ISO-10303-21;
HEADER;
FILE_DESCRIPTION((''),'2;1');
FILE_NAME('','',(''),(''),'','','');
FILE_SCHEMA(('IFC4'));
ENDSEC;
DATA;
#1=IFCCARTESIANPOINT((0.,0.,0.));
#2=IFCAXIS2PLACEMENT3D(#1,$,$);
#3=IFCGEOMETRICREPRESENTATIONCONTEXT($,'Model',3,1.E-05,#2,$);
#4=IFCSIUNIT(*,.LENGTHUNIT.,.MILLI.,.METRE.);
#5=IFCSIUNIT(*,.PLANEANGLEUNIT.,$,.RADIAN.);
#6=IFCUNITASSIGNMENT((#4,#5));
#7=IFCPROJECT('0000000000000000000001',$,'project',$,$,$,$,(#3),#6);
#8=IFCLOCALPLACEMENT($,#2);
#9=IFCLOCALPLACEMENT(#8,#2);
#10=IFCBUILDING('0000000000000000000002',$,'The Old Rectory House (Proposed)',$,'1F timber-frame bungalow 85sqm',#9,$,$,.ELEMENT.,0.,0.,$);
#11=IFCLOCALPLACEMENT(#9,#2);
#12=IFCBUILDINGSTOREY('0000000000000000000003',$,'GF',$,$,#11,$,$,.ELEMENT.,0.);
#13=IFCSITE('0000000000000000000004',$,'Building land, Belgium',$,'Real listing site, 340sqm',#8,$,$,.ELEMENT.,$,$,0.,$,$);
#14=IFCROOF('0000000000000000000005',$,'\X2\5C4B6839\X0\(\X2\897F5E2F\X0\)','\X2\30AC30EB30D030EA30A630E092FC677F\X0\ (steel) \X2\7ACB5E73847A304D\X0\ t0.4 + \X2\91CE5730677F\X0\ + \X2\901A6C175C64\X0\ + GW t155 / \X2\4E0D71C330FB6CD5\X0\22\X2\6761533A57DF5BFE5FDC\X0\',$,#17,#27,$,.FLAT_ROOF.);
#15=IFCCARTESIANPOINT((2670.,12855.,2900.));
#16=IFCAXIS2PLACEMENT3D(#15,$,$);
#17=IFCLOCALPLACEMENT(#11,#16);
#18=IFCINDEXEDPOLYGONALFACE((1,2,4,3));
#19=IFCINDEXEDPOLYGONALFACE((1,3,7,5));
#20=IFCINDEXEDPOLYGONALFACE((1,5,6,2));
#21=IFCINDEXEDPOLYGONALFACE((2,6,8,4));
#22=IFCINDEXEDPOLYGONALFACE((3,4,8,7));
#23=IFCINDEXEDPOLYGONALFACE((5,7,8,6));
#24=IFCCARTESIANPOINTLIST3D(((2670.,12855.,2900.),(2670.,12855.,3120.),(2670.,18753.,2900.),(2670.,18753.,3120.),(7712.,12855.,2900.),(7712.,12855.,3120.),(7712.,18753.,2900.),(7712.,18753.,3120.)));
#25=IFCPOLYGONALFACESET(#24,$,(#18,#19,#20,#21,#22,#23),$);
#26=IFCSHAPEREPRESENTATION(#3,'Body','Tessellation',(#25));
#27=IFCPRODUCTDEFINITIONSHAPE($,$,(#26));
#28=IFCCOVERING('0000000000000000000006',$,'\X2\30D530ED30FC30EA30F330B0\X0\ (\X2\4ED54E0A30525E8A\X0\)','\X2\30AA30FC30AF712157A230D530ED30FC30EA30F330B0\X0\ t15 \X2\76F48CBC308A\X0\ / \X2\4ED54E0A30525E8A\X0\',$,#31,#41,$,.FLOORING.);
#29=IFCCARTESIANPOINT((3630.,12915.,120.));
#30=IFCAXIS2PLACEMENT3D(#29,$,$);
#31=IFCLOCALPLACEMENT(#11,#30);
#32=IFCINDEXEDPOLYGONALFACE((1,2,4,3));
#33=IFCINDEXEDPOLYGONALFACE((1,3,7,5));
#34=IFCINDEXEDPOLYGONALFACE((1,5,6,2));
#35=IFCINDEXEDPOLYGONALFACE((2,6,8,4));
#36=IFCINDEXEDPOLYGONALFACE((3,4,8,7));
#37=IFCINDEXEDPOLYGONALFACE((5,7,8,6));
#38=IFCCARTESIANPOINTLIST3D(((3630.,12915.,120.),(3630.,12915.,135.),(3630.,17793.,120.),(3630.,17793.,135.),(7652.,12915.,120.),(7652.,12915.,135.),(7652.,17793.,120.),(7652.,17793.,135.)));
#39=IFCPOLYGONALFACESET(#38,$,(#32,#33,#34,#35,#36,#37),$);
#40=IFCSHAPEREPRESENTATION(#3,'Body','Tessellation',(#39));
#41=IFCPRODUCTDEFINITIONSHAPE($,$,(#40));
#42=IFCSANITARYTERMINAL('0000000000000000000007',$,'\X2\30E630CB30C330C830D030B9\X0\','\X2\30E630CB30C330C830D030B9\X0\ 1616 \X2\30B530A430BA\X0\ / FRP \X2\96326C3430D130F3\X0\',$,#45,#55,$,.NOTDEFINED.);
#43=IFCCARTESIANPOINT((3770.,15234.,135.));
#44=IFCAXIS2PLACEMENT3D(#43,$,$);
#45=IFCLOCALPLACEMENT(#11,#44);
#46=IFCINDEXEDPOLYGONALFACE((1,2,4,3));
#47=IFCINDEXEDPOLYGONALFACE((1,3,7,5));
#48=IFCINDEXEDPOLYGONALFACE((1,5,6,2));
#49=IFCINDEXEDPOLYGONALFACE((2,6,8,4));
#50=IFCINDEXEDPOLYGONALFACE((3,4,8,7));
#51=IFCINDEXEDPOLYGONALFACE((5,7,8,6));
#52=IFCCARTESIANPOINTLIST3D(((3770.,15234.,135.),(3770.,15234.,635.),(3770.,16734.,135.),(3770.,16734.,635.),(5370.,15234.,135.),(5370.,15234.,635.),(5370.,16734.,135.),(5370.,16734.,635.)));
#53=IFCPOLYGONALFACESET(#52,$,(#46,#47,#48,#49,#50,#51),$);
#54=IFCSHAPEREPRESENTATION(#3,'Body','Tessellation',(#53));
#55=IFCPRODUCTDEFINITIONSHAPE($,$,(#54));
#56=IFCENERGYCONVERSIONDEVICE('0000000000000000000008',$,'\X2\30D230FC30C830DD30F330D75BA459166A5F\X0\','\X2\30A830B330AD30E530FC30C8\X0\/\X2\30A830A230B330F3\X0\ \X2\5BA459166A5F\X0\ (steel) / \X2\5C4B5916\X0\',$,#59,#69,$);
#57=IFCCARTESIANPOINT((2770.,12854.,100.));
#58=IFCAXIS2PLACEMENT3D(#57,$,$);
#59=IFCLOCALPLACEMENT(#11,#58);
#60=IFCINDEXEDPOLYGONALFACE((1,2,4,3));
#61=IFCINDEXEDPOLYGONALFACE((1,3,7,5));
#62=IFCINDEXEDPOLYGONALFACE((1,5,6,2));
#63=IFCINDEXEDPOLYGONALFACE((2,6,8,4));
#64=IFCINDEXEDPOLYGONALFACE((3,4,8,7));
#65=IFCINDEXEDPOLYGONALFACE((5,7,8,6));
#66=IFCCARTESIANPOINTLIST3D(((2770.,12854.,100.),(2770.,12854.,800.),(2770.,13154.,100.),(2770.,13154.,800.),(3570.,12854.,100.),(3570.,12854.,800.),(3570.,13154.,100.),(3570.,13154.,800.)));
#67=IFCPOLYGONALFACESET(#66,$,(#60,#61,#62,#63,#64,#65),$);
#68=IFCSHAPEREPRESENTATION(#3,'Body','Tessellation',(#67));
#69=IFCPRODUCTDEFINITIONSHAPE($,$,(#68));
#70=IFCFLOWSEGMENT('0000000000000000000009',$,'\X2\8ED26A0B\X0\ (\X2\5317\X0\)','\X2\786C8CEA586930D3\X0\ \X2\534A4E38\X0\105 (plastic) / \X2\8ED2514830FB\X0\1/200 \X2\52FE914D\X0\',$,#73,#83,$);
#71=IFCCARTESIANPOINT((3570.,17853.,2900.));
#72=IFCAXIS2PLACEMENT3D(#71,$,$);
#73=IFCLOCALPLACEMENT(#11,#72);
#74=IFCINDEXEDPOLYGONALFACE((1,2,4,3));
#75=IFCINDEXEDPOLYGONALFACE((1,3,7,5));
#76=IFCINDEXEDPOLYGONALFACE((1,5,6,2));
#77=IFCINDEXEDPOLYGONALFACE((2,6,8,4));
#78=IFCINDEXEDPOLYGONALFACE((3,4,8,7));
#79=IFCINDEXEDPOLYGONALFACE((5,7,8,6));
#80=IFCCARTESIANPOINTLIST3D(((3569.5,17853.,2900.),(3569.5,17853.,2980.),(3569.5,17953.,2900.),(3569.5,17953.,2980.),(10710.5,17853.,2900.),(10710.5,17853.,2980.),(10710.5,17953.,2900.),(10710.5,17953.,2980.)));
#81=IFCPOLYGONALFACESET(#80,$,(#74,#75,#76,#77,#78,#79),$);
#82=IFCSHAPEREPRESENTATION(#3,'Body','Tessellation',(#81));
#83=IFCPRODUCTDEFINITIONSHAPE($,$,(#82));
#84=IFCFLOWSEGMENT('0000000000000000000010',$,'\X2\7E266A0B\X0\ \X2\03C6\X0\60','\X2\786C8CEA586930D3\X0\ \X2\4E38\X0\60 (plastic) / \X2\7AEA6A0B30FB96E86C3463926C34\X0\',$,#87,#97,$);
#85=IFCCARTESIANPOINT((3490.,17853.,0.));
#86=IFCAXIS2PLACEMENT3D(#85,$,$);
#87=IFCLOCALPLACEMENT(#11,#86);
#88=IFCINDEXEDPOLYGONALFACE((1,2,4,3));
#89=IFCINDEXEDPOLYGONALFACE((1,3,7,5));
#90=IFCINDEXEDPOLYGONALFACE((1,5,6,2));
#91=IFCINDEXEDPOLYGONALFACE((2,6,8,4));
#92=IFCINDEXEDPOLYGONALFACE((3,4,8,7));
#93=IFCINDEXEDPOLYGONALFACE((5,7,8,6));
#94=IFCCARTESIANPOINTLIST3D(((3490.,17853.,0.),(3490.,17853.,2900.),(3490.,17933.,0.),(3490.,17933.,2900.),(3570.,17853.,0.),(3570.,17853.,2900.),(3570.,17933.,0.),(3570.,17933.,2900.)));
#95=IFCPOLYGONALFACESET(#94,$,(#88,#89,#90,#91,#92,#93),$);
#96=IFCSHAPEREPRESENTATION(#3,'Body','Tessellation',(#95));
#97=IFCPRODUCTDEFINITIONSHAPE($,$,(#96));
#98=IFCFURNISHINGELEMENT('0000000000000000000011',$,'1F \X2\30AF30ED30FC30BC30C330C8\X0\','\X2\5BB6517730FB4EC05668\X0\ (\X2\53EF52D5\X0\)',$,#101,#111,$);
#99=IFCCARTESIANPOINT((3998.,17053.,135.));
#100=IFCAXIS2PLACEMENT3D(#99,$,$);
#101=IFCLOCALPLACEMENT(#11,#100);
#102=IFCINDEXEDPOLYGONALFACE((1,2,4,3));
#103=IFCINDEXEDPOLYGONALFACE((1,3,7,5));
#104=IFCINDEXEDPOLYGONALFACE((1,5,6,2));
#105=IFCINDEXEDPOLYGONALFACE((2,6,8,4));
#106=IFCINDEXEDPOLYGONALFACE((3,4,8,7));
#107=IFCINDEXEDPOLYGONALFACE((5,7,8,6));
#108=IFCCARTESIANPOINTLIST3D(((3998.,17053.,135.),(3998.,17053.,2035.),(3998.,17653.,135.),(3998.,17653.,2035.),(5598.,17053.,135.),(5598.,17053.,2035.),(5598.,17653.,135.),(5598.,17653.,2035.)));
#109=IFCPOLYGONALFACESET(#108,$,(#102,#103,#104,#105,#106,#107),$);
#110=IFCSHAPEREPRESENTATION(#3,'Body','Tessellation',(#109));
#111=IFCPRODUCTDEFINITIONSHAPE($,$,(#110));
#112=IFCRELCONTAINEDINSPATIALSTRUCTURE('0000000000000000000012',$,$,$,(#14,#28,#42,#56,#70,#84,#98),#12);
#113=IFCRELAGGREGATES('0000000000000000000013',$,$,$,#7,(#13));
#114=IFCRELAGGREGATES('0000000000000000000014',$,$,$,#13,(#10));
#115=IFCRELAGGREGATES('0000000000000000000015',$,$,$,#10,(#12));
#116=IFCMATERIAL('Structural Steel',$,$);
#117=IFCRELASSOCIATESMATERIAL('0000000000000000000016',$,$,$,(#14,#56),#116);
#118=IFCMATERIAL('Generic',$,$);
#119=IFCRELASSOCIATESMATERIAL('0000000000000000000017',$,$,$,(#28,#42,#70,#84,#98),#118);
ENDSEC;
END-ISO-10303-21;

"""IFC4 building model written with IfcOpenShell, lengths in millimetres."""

from ifc_helpers import new_model, si_unit, frame, frame_2d, origin, place, context, project, spatial, rectangle, extrude, material, element, save


model = new_model("IFC4")

# Units and contexts
model_context = context("Model", 3, precision=1e-05, world=origin())
ifc_project = project(units=[si_unit("LENGTHUNIT", "METRE", prefix="MILLI"), si_unit("PLANEANGLEUNIT", "RADIAN")], contexts=[model_context])

# Site, building, storey
site_placement = place(None, origin())
site = spatial("IfcSite", under=ifc_project, at=site_placement, Name="Building land, Belgium", ObjectType="Real listing site, 340sqm", CompositionType="ELEMENT", RefElevation=0.0)
building_placement = place(site_placement, origin())
building = spatial("IfcBuilding", under=site, at=building_placement, Name="The Old Rectory House (Proposed)", ObjectType="1F timber-frame bungalow 85sqm", CompositionType="ELEMENT", ElevationOfRefHeight=0.0, ElevationOfTerrain=0.0)
storey_placement = place(building_placement, origin())
storey = spatial("IfcBuildingStorey", under=building, at=storey_placement, Name="GF", CompositionType="ELEMENT", Elevation=0.0)

# Roof
ifc_material_1 = material(Name="Structural Steel")
roof_placement = place(storey_placement, frame((2670.0, 12855.0, 2900.0)))
element("IfcRoof", 1, at=roof_placement, inside=storey, material=ifc_material_1, Name="屋根(西帯)", Description="ガルバリウム鋼板 (steel) 立平葺き t0.4 + 野地板 + 通気層 + GW t155 / 不燃・法22条区域対応", PredefinedType="FLAT_ROOF", context=model_context, shape_type="SweptSolid", body=[
    extrude(rectangle(XDim=5042.0, YDim=5898.0, at=frame_2d((2521.0, 2949.0))), frame((2670.0, 12855.0, 2900.0)), (0.0, 0.0, 1.0), 220.0),
])

# Covering
ifc_material_2 = material(Name="Generic")
covering_placement = place(storey_placement, frame((3630.0, 12915.0, 120.0)))
element("IfcCovering", 2, at=covering_placement, inside=storey, material=ifc_material_2, Name="フローリング (仕上げ床)", Description="オーク無垢フローリング t15 直貼り / 仕上げ床", PredefinedType="FLOORING", context=model_context, shape_type="SweptSolid", body=[
    extrude(rectangle(XDim=4022.0, YDim=4878.0, at=frame_2d((2011.0, 2439.0))), frame((3630.0, 12915.0, 120.0)), (0.0, 0.0, 1.0), 15.0),
])

# Sanitary terminal
sanitary_terminal_placement = place(storey_placement, frame((3770.0, 15234.0, 135.0)))
element("IfcSanitaryTerminal", 3, at=sanitary_terminal_placement, inside=storey, material=ifc_material_2, Name="ユニットバス", Description="ユニットバス 1616 サイズ / FRP 防水パン", PredefinedType="NOTDEFINED", context=model_context, shape_type="SweptSolid", body=[
    extrude(rectangle(XDim=1600.0, YDim=1500.0, at=frame_2d((800.0, 750.0))), frame((3770.0, 15234.0, 135.0)), (0.0, 0.0, 1.0), 500.0),
])

# Energy conversion device
energy_conversion_device_placement = place(storey_placement, frame((2770.0, 12854.0, 100.0)))
element("IfcEnergyConversionDevice", 4, at=energy_conversion_device_placement, inside=storey, material=ifc_material_1, Name="ヒートポンプ室外機", Description="エコキュート/エアコン 室外機 (steel) / 屋外", context=model_context, shape_type="SweptSolid", body=[
    extrude(rectangle(XDim=800.0, YDim=300.0, at=frame_2d((400.0, 150.0))), frame((2770.0, 12854.0, 100.0)), (0.0, 0.0, 1.0), 700.0),
])

# Flow segments
flow_segment_1_placement = place(storey_placement, frame((3570.0, 17853.0, 2900.0)))
element("IfcFlowSegment", 5, at=flow_segment_1_placement, inside=storey, material=ifc_material_2, Name="軒樋 (北)", Description="硬質塩ビ 半丸105 (plastic) / 軒先・1/200 勾配", context=model_context, shape_type="SweptSolid", body=[
    extrude(rectangle(XDim=7141.0, YDim=100.0, at=frame_2d((3570.0, 50.0))), frame((3570.0, 17853.0, 2900.0)), (0.0, 0.0, 1.0), 80.0),
])
flow_segment_2_placement = place(storey_placement, frame((3490.0, 17853.0, 0.0)))
element("IfcFlowSegment", 6, at=flow_segment_2_placement, inside=storey, material=ifc_material_2, Name="縦樋 φ60", Description="硬質塩ビ 丸60 (plastic) / 竪樋・雨水排水", context=model_context, shape_type="SweptSolid", body=[
    extrude(rectangle(XDim=80.0, YDim=80.0, at=frame_2d((40.0, 40.0))), frame((3490.0, 17853.0, 0.0)), (0.0, 0.0, 1.0), 2900.0),
])

# Furnishing element
furnishing_placement = place(storey_placement, frame((3998.0, 17053.0, 135.0)))
element("IfcFurnishingElement", 7, at=furnishing_placement, inside=storey, material=ifc_material_2, Name="1F クローゼット", Description="家具・什器 (可動)", context=model_context, shape_type="SweptSolid", body=[
    extrude(rectangle(XDim=1600.0, YDim=600.0, at=frame_2d((800.0, 300.0))), frame((3998.0, 17053.0, 135.0)), (0.0, 0.0, 1.0), 1900.0),
])

save(model, "model.ifc")
